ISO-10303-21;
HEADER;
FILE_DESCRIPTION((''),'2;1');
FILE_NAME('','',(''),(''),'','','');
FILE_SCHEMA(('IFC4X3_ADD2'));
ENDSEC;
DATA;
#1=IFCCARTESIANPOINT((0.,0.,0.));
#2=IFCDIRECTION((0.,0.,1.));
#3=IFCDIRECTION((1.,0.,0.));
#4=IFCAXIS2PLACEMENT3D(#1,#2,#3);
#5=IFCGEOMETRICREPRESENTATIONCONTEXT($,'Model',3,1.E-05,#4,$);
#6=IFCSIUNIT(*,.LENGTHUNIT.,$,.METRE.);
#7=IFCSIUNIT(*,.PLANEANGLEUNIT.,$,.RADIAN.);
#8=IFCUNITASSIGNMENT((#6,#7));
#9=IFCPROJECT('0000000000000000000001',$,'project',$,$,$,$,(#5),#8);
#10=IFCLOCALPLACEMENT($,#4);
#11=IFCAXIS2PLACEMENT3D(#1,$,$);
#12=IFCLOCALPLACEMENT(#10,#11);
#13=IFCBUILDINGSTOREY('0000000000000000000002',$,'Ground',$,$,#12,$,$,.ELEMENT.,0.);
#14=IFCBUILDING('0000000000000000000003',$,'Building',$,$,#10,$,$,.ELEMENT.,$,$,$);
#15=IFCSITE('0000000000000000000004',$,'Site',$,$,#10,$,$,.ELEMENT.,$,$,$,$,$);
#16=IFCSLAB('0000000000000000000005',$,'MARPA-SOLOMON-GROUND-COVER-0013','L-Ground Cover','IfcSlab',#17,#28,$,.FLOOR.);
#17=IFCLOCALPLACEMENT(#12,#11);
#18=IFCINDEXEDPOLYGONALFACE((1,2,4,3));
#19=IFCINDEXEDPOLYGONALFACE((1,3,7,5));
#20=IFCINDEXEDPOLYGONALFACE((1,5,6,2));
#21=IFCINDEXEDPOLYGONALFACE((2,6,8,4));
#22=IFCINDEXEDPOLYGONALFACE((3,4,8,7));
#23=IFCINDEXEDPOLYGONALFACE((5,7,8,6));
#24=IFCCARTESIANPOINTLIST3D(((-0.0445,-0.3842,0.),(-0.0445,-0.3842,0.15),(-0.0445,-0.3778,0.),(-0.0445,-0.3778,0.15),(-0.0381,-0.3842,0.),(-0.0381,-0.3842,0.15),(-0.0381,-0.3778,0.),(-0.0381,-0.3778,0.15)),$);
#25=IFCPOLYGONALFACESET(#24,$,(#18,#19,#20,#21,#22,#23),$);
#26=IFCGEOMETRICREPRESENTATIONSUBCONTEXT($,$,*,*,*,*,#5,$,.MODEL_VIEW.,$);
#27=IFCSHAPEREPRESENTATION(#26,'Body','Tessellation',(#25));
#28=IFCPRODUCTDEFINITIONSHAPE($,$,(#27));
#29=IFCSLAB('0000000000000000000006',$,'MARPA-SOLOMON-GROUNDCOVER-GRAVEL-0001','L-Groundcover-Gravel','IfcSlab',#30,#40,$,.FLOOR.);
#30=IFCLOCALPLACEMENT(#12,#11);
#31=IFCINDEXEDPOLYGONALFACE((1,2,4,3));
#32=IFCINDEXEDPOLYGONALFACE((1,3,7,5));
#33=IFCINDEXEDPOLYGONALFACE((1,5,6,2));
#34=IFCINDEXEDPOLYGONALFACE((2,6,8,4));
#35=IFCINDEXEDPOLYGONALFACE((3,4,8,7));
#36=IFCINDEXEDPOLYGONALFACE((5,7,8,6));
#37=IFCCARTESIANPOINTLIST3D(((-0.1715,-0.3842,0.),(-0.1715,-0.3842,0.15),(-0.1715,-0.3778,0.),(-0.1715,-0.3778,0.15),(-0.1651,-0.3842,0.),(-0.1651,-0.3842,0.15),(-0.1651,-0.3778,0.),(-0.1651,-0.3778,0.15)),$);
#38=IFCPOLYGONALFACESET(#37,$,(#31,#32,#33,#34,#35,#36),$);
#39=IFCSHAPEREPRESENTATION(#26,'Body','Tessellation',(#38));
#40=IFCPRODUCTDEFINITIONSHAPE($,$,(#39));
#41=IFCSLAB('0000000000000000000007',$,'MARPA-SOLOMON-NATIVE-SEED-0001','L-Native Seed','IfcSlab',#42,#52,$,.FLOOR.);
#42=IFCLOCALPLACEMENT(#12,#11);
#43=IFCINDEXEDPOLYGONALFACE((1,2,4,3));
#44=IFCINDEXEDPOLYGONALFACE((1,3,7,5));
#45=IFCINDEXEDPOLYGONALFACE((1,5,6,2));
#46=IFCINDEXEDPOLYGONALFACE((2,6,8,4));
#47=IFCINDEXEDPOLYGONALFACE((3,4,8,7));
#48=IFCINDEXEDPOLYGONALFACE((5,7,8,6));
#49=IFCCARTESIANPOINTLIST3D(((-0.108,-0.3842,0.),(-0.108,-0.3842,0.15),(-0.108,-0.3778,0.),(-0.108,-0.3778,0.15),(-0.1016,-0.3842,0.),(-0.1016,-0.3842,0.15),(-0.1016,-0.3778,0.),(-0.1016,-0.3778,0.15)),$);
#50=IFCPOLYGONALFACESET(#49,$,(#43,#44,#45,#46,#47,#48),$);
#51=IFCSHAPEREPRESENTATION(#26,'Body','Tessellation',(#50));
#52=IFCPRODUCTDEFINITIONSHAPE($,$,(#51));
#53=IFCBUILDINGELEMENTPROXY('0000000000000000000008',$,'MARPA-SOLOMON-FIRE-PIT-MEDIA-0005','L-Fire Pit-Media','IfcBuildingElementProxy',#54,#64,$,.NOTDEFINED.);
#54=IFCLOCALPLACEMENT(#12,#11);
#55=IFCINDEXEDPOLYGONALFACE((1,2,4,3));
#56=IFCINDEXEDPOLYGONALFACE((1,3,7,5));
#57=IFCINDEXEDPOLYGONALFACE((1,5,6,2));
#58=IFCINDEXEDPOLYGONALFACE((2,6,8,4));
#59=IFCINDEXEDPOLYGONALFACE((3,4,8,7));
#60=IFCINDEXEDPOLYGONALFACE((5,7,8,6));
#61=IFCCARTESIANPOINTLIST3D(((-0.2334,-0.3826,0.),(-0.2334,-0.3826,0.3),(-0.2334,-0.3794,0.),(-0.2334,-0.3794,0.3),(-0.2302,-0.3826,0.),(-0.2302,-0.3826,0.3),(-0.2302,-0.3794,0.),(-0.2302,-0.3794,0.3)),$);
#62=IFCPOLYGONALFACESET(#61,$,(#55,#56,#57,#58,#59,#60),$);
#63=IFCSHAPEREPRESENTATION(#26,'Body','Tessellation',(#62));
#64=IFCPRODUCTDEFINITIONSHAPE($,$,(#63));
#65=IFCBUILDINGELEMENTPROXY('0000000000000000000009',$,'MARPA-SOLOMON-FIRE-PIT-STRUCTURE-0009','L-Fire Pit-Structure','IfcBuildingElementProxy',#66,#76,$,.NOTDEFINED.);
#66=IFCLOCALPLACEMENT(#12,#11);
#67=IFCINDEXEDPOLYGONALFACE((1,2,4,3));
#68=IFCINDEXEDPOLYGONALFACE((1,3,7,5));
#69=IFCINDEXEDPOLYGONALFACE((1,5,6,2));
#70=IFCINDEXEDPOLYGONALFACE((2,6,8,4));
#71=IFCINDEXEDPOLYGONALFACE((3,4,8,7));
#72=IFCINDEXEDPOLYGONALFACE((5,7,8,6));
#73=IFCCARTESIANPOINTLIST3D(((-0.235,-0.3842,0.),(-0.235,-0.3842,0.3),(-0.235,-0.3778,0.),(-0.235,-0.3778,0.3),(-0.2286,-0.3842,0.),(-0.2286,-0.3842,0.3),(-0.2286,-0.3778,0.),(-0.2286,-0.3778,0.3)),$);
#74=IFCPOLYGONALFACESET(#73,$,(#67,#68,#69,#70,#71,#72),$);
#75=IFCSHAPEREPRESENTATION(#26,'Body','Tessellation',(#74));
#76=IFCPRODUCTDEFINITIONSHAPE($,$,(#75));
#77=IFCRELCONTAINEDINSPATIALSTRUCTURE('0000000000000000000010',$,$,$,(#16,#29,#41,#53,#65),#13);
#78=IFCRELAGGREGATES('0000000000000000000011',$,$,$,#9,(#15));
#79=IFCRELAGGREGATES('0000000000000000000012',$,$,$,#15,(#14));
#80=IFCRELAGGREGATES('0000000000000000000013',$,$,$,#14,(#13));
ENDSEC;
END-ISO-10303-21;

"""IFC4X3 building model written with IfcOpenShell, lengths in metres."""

from ifc_helpers import new_model, si_unit, frame, origin, origin_with_axes, place, context, subcontext, project, spatial, polyline, outline, extrude, element, save


model = new_model("IFC4X3")

# Units and contexts
model_context = context("Model", 3, precision=1e-05, world=origin_with_axes())
sub_context = subcontext(model_context, None, None, "MODEL_VIEW")
ifc_project = project(units=[si_unit("LENGTHUNIT", "METRE"), si_unit("PLANEANGLEUNIT", "RADIAN")], contexts=[model_context])

# Site, building, storey
placement = place(None, origin_with_axes())
site = spatial("IfcSite", under=ifc_project, at=placement, Name="Site", CompositionType="ELEMENT")
building = spatial("IfcBuilding", under=site, at=placement, Name="Building", CompositionType="ELEMENT")
storey_placement = place(placement, origin())
storey = spatial("IfcBuildingStorey", under=building, at=storey_placement, Name="Ground", CompositionType="ELEMENT", Elevation=0.0)

# Slabs
for number, where, name in (
    (1, (-0.0445, -0.3842, 0.0), "MARPA-SOLOMON-GROUND-COVER-0013"),
):
    element("IfcSlab", number, at=place(storey_placement, frame(where)), inside=storey, Name=name, Description="L-Ground Cover", ObjectType="IfcSlab", PredefinedType="FLOOR", context=sub_context, shape_type="SweptSolid", body=[
        extrude(outline(polyline([(0.0, 0.0064), (0.0063, 0.0064), (0.0063, 0.0), (0.0, 0.0), (0.0, 0.0064)])), origin(), (0.0, 0.0, 1.0), 0.15),
    ])
for number, where, name, description in (
    (2, (-0.1715, -0.3842, 0.0), "MARPA-SOLOMON-GROUNDCOVER-GRAVEL-0001", "L-Groundcover-Gravel"),
    (3, (-0.108, -0.3842, 0.0), "MARPA-SOLOMON-NATIVE-SEED-0001", "L-Native Seed"),
):
    element("IfcSlab", number, at=place(storey_placement, frame(where)), inside=storey, Name=name, Description=description, ObjectType="IfcSlab", PredefinedType="FLOOR", context=sub_context, shape_type="SweptSolid", body=[
        extrude(outline(polyline([(0.0, 0.0064), (0.0063, 0.0064), (0.0063, 0.0), (0.0, 0.0), (0.0, 0.0064)])), origin(), (0.0, 0.0, 1.0), 0.15),
    ])

# Building element proxies
for number, where, name in (
    (4, (-0.2334, -0.3826, 0.0), "MARPA-SOLOMON-FIRE-PIT-MEDIA-0005"),
):
    element("IfcBuildingElementProxy", number, at=place(placement, frame(where)), inside=storey, Name=name, Description="L-Fire Pit-Media", ObjectType="IfcBuildingElementProxy", PredefinedType="NOTDEFINED", context=sub_context, shape_type="SweptSolid", body=[
        extrude(outline(polyline([(0.0, 0.0032), (0.0032, 0.0032), (0.0032, 0.0), (0.0, 0.0), (0.0, 0.0032)])), origin(), (0.0, 0.0, 1.0), 0.3),
    ])
for number, where, name in (
    (5, (-0.235, -0.3842, 0.0), "MARPA-SOLOMON-FIRE-PIT-STRUCTURE-0009"),
):
    element("IfcBuildingElementProxy", number, at=place(placement, frame(where)), inside=storey, Name=name, Description="L-Fire Pit-Structure", ObjectType="IfcBuildingElementProxy", PredefinedType="NOTDEFINED", context=sub_context, shape_type="SweptSolid", body=[
        extrude(outline(polyline([(0.0, 0.0064), (0.0063, 0.0064), (0.0063, 0.0), (0.0, 0.0), (0.0, 0.0064)])), origin(), (0.0, 0.0, 1.0), 0.3),
    ])

save(model, "model.ifc")
